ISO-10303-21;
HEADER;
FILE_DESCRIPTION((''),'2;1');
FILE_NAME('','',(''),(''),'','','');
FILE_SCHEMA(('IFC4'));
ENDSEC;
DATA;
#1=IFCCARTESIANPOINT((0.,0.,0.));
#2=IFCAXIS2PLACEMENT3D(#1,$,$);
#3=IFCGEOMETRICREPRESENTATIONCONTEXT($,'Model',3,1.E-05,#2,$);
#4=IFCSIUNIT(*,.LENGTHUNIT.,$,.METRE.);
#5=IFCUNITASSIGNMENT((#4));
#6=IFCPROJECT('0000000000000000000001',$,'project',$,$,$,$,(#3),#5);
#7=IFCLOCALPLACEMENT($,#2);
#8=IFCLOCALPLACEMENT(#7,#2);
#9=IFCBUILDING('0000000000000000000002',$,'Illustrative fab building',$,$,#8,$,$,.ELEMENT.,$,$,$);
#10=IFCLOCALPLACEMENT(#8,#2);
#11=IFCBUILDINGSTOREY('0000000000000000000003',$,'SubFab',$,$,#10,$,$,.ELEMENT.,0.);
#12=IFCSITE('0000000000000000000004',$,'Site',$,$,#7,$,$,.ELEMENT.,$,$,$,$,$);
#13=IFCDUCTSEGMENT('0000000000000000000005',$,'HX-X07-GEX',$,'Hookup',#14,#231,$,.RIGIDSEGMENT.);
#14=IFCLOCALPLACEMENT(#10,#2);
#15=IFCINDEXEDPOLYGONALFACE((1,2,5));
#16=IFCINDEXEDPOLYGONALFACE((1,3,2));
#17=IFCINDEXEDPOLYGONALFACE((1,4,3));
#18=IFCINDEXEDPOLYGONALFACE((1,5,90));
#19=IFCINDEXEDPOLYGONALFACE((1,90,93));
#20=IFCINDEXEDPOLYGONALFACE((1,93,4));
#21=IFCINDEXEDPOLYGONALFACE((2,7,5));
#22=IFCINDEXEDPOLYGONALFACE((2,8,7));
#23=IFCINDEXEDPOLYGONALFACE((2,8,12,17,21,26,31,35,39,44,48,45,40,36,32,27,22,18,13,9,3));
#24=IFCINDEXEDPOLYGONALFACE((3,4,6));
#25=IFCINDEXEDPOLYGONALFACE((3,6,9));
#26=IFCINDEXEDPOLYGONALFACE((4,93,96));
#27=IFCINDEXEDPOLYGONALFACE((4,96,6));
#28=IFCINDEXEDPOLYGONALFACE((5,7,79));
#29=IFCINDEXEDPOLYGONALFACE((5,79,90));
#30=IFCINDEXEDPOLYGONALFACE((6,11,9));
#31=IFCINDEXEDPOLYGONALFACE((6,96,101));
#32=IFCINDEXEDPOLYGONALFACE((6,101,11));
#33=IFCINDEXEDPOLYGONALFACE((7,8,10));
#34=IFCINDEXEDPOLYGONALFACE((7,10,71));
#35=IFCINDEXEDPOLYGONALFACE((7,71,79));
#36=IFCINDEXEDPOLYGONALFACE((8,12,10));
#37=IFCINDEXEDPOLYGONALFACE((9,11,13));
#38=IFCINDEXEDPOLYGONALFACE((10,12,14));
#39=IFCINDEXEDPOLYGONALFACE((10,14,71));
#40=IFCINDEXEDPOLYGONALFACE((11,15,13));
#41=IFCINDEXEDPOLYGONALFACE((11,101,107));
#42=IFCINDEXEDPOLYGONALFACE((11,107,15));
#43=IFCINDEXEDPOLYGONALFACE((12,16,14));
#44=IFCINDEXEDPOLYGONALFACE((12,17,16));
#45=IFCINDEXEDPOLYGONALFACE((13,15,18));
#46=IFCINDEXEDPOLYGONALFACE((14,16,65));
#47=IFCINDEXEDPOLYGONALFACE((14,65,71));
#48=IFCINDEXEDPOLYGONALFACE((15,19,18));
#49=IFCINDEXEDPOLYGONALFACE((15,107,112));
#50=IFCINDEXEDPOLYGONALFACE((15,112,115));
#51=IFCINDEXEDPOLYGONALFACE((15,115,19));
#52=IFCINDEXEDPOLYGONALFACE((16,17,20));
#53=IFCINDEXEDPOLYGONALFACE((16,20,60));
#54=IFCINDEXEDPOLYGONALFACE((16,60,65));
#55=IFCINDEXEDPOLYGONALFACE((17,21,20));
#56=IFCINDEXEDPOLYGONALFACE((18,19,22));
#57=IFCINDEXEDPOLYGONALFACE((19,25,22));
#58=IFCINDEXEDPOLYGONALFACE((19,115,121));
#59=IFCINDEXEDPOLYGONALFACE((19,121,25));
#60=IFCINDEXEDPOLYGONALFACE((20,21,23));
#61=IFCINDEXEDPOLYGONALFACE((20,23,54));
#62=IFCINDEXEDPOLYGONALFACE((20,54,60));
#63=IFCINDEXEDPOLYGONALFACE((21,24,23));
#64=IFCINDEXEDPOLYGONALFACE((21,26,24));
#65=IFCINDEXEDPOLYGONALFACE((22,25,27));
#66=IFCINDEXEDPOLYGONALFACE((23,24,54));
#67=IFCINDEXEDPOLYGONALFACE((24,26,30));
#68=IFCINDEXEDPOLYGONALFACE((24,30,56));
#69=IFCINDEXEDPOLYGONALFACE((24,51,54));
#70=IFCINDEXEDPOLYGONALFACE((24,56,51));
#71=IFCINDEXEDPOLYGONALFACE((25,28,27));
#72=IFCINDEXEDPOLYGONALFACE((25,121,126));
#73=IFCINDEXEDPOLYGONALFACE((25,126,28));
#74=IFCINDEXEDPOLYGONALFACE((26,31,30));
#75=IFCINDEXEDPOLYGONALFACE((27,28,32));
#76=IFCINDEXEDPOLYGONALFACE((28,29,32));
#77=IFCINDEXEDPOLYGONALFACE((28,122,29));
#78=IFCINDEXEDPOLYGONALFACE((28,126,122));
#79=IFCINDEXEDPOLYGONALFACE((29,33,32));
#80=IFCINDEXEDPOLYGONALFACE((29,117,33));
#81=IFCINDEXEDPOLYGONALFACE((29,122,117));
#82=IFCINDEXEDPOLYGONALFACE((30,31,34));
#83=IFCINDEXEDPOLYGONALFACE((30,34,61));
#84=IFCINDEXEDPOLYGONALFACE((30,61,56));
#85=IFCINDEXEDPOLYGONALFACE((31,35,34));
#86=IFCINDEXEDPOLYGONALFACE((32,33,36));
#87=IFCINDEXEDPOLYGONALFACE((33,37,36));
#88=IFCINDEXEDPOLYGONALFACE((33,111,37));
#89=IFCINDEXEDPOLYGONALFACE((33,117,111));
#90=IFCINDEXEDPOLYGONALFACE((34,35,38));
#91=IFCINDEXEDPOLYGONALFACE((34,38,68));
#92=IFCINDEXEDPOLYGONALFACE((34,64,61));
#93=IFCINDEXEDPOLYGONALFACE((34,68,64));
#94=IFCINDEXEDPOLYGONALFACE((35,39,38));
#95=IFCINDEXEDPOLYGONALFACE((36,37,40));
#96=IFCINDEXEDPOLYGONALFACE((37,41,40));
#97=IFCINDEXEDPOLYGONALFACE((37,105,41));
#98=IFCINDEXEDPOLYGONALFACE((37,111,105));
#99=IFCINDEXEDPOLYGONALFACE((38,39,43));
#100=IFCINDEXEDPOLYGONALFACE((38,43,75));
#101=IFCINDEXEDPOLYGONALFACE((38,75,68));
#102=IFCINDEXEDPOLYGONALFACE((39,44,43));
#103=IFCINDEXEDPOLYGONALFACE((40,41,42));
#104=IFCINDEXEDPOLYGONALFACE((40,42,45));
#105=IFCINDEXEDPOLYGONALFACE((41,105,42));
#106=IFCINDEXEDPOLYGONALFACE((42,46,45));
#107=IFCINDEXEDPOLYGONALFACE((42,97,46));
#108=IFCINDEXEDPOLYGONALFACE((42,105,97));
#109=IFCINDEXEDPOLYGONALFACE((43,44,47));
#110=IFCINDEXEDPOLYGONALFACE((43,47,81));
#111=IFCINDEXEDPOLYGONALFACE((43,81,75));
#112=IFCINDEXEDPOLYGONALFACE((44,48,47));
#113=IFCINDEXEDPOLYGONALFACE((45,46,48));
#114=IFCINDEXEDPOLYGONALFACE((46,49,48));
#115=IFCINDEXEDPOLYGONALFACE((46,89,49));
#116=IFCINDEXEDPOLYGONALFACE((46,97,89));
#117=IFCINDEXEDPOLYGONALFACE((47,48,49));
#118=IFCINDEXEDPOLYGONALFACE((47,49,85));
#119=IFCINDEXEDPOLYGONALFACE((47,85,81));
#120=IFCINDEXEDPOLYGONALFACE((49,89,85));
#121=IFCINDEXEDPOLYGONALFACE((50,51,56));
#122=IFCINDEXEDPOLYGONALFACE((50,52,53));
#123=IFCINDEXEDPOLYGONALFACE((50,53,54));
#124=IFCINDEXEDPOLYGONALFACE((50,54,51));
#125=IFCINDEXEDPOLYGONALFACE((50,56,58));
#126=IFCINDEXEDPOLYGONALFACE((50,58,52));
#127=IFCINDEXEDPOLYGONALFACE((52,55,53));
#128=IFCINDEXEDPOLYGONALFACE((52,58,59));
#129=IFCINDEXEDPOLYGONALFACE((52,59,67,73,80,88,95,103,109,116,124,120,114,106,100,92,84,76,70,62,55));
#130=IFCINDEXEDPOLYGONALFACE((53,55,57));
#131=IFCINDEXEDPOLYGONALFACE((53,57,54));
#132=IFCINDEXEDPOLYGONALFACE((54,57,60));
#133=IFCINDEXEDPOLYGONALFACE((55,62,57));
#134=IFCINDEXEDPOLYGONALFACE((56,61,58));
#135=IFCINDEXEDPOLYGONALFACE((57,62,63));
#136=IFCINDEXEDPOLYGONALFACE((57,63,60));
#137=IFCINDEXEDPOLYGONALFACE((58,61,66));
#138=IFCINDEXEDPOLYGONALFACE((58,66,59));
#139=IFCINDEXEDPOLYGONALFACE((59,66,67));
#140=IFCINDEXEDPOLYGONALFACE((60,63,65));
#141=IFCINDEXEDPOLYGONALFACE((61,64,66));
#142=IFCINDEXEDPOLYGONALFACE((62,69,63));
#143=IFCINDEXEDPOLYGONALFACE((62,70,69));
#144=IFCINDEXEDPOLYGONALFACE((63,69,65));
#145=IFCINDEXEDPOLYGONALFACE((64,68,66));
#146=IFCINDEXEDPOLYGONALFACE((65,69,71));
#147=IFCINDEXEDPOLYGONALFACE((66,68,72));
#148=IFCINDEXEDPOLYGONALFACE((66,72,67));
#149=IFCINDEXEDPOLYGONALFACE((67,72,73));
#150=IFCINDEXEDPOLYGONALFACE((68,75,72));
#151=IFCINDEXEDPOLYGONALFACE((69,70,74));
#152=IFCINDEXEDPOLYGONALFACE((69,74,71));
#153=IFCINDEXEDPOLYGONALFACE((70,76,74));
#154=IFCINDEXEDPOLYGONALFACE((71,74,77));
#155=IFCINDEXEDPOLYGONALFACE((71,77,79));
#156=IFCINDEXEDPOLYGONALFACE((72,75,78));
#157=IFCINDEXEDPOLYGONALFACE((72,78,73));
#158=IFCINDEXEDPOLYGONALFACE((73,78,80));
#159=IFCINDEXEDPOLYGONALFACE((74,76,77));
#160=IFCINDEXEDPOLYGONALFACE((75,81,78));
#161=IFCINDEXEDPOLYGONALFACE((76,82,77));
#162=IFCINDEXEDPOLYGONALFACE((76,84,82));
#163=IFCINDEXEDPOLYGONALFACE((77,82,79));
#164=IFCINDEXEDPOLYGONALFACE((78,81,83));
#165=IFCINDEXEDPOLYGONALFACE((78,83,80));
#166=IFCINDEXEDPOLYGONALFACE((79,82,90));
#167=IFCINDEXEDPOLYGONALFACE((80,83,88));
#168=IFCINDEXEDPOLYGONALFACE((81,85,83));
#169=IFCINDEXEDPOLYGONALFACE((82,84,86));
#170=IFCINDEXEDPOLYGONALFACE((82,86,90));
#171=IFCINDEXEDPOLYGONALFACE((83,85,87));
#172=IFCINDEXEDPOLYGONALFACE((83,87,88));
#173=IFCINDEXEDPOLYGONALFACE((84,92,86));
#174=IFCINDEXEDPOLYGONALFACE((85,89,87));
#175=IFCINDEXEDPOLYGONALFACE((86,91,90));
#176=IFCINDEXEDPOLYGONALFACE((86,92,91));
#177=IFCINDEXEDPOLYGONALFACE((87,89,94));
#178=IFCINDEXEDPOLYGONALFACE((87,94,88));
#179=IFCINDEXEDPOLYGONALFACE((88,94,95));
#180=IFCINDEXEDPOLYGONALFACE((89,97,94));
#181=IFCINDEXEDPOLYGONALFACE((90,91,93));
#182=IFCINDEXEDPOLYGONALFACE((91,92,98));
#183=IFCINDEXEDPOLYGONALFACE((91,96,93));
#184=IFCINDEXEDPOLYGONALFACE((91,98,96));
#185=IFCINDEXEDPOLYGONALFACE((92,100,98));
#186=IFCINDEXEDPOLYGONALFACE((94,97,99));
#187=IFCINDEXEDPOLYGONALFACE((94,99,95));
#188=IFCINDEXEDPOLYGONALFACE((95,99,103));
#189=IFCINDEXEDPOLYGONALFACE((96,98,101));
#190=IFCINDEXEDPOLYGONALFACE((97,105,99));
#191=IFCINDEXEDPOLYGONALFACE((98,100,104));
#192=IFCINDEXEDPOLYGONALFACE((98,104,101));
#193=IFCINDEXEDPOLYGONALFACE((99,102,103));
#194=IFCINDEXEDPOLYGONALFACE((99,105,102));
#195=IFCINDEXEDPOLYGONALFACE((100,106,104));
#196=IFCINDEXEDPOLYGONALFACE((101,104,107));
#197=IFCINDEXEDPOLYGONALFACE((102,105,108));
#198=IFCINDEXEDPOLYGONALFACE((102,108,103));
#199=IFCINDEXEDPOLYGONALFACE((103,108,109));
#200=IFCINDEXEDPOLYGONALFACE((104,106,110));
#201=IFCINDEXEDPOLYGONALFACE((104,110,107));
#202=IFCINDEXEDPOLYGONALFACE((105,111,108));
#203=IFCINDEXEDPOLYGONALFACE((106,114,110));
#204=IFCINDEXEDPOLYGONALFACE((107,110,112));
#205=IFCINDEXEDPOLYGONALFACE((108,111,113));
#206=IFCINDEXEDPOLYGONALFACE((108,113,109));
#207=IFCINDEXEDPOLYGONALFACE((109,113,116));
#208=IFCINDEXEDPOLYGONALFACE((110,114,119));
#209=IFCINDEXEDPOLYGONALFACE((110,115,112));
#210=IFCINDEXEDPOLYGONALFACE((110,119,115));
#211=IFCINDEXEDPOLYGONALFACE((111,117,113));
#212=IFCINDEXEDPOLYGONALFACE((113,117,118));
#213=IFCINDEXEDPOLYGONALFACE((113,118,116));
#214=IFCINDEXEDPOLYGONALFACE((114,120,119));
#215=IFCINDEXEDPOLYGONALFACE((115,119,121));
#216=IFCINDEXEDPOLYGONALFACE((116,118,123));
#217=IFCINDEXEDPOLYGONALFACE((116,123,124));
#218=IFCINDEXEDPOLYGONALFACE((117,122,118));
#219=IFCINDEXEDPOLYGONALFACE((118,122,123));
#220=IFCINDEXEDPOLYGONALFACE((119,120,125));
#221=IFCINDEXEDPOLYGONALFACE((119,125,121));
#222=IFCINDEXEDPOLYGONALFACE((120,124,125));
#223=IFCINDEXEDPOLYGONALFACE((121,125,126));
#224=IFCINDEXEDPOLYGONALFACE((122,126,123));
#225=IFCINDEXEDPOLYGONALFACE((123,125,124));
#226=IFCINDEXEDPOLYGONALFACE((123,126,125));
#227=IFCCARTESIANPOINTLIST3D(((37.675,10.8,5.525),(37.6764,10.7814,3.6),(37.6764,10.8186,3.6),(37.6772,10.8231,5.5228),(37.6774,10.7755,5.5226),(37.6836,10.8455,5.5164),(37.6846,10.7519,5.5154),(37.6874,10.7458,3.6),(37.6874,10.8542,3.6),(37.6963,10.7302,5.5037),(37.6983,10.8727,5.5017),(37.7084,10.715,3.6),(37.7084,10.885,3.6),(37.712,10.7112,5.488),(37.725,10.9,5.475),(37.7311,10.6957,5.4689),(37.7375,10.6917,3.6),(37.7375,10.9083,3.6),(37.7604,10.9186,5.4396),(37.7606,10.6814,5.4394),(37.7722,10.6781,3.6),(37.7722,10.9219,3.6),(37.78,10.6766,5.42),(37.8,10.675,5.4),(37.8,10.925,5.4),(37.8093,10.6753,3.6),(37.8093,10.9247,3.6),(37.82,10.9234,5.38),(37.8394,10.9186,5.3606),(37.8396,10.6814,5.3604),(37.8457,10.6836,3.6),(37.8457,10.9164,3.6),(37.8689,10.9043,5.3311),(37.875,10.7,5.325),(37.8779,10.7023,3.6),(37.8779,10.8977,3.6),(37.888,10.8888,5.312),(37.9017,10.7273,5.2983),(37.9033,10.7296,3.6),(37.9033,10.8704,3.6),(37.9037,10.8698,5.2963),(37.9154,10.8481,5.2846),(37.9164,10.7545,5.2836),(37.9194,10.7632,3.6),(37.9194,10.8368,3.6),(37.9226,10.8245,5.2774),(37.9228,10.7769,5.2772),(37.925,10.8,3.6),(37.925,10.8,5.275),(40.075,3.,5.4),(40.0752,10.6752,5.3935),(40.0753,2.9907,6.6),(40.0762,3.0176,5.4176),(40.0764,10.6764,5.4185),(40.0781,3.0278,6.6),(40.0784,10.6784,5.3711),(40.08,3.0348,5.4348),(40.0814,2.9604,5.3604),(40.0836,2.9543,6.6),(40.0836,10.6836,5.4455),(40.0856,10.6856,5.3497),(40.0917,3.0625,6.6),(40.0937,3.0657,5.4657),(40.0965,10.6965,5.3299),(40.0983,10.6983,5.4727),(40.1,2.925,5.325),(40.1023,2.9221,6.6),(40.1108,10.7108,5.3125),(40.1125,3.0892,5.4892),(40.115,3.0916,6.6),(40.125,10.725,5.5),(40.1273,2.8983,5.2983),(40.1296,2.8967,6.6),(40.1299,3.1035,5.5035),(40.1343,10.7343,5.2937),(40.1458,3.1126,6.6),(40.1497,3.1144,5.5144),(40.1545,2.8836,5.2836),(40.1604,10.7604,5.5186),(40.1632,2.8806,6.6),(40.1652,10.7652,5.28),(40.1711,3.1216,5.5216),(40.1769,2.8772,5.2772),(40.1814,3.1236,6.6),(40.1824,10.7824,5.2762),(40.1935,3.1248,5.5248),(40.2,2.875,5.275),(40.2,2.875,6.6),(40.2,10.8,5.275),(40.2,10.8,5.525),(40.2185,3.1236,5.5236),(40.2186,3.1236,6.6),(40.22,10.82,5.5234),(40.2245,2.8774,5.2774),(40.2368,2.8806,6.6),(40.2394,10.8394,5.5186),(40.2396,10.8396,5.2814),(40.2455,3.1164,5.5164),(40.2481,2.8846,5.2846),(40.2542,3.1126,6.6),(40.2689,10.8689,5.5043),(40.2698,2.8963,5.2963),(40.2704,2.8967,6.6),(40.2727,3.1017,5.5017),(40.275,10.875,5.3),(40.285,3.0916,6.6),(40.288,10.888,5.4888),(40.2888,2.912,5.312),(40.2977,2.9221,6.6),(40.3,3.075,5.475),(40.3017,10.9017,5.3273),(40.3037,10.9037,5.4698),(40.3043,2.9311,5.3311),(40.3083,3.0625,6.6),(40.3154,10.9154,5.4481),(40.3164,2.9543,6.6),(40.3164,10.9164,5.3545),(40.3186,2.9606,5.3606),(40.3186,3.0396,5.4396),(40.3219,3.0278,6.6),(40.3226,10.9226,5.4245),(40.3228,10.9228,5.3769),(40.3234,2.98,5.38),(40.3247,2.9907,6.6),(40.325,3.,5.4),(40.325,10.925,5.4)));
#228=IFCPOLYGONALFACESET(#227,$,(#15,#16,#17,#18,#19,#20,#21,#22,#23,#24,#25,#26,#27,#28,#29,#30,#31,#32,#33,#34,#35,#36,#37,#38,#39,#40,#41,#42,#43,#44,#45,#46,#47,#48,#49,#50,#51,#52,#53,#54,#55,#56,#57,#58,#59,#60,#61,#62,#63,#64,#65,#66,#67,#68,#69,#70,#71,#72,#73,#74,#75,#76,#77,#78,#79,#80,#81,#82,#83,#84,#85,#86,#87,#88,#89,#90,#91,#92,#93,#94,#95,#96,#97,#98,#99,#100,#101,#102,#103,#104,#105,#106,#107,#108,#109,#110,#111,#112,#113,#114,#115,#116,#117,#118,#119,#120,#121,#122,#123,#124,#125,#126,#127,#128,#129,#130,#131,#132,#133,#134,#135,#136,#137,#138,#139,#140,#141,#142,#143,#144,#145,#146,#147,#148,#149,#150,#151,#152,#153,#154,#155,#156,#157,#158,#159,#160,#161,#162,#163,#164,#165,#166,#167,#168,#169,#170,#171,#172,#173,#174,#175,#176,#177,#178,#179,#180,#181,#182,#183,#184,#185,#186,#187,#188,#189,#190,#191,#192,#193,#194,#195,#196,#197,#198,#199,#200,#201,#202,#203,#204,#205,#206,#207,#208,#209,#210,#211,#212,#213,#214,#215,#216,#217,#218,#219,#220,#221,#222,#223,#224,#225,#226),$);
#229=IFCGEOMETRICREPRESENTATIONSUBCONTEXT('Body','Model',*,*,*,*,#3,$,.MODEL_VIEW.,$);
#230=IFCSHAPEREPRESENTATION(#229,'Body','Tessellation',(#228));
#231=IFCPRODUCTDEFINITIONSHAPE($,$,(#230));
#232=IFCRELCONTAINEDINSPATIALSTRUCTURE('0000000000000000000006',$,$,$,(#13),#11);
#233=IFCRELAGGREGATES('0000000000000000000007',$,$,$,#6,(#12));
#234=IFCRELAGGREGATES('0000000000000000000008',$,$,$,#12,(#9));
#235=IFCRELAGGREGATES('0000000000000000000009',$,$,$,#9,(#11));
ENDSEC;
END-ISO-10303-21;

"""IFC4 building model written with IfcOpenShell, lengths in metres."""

from ifc_helpers import new_model, entity, si_unit, origin, place, context, subcontext, project, spatial, element, save


model = new_model("IFC4")

# Units and contexts
model_context = context("Model", 3, precision=1e-05, world=origin())
body_context = subcontext(model_context, "Body", "Model", "MODEL_VIEW")
ifc_project = project(units=[si_unit("LENGTHUNIT", "METRE")], contexts=[model_context])

# Site, building, storey
site_placement = place(None, origin())
site = spatial("IfcSite", under=ifc_project, at=site_placement, Name="Site", CompositionType="ELEMENT")
building_placement = place(site_placement, origin())
building = spatial("IfcBuilding", under=site, at=building_placement, Name="Illustrative fab building", CompositionType="ELEMENT")
storey_placement = place(building_placement, origin())
storey = spatial("IfcBuildingStorey", under=building, at=storey_placement, Name="SubFab", CompositionType="ELEMENT", Elevation=0.0)

# Duct segment
duct_segment_1_placement = place(storey_placement, origin())
element("IfcDuctSegment", 1, at=duct_segment_1_placement, inside=storey, Name="HX-X07-GEX", ObjectType="Hookup", PredefinedType="RIGIDSEGMENT", context=body_context, shape_type="AdvancedSweptSolid", body=[
    entity("IfcSweptDiskSolid", entity("IfcPolyline", [entity("IfcCartesianPoint", [37.8, 10.8, 3.6]), entity("IfcCartesianPoint", [37.8, 10.8, 5.4]), entity("IfcCartesianPoint", [40.2, 10.8, 5.4]), entity("IfcCartesianPoint", [40.2, 3.0, 5.4]), entity("IfcCartesianPoint", [40.2, 3.0, 6.6])]), 0.125),
])

save(model, "model.ifc")
